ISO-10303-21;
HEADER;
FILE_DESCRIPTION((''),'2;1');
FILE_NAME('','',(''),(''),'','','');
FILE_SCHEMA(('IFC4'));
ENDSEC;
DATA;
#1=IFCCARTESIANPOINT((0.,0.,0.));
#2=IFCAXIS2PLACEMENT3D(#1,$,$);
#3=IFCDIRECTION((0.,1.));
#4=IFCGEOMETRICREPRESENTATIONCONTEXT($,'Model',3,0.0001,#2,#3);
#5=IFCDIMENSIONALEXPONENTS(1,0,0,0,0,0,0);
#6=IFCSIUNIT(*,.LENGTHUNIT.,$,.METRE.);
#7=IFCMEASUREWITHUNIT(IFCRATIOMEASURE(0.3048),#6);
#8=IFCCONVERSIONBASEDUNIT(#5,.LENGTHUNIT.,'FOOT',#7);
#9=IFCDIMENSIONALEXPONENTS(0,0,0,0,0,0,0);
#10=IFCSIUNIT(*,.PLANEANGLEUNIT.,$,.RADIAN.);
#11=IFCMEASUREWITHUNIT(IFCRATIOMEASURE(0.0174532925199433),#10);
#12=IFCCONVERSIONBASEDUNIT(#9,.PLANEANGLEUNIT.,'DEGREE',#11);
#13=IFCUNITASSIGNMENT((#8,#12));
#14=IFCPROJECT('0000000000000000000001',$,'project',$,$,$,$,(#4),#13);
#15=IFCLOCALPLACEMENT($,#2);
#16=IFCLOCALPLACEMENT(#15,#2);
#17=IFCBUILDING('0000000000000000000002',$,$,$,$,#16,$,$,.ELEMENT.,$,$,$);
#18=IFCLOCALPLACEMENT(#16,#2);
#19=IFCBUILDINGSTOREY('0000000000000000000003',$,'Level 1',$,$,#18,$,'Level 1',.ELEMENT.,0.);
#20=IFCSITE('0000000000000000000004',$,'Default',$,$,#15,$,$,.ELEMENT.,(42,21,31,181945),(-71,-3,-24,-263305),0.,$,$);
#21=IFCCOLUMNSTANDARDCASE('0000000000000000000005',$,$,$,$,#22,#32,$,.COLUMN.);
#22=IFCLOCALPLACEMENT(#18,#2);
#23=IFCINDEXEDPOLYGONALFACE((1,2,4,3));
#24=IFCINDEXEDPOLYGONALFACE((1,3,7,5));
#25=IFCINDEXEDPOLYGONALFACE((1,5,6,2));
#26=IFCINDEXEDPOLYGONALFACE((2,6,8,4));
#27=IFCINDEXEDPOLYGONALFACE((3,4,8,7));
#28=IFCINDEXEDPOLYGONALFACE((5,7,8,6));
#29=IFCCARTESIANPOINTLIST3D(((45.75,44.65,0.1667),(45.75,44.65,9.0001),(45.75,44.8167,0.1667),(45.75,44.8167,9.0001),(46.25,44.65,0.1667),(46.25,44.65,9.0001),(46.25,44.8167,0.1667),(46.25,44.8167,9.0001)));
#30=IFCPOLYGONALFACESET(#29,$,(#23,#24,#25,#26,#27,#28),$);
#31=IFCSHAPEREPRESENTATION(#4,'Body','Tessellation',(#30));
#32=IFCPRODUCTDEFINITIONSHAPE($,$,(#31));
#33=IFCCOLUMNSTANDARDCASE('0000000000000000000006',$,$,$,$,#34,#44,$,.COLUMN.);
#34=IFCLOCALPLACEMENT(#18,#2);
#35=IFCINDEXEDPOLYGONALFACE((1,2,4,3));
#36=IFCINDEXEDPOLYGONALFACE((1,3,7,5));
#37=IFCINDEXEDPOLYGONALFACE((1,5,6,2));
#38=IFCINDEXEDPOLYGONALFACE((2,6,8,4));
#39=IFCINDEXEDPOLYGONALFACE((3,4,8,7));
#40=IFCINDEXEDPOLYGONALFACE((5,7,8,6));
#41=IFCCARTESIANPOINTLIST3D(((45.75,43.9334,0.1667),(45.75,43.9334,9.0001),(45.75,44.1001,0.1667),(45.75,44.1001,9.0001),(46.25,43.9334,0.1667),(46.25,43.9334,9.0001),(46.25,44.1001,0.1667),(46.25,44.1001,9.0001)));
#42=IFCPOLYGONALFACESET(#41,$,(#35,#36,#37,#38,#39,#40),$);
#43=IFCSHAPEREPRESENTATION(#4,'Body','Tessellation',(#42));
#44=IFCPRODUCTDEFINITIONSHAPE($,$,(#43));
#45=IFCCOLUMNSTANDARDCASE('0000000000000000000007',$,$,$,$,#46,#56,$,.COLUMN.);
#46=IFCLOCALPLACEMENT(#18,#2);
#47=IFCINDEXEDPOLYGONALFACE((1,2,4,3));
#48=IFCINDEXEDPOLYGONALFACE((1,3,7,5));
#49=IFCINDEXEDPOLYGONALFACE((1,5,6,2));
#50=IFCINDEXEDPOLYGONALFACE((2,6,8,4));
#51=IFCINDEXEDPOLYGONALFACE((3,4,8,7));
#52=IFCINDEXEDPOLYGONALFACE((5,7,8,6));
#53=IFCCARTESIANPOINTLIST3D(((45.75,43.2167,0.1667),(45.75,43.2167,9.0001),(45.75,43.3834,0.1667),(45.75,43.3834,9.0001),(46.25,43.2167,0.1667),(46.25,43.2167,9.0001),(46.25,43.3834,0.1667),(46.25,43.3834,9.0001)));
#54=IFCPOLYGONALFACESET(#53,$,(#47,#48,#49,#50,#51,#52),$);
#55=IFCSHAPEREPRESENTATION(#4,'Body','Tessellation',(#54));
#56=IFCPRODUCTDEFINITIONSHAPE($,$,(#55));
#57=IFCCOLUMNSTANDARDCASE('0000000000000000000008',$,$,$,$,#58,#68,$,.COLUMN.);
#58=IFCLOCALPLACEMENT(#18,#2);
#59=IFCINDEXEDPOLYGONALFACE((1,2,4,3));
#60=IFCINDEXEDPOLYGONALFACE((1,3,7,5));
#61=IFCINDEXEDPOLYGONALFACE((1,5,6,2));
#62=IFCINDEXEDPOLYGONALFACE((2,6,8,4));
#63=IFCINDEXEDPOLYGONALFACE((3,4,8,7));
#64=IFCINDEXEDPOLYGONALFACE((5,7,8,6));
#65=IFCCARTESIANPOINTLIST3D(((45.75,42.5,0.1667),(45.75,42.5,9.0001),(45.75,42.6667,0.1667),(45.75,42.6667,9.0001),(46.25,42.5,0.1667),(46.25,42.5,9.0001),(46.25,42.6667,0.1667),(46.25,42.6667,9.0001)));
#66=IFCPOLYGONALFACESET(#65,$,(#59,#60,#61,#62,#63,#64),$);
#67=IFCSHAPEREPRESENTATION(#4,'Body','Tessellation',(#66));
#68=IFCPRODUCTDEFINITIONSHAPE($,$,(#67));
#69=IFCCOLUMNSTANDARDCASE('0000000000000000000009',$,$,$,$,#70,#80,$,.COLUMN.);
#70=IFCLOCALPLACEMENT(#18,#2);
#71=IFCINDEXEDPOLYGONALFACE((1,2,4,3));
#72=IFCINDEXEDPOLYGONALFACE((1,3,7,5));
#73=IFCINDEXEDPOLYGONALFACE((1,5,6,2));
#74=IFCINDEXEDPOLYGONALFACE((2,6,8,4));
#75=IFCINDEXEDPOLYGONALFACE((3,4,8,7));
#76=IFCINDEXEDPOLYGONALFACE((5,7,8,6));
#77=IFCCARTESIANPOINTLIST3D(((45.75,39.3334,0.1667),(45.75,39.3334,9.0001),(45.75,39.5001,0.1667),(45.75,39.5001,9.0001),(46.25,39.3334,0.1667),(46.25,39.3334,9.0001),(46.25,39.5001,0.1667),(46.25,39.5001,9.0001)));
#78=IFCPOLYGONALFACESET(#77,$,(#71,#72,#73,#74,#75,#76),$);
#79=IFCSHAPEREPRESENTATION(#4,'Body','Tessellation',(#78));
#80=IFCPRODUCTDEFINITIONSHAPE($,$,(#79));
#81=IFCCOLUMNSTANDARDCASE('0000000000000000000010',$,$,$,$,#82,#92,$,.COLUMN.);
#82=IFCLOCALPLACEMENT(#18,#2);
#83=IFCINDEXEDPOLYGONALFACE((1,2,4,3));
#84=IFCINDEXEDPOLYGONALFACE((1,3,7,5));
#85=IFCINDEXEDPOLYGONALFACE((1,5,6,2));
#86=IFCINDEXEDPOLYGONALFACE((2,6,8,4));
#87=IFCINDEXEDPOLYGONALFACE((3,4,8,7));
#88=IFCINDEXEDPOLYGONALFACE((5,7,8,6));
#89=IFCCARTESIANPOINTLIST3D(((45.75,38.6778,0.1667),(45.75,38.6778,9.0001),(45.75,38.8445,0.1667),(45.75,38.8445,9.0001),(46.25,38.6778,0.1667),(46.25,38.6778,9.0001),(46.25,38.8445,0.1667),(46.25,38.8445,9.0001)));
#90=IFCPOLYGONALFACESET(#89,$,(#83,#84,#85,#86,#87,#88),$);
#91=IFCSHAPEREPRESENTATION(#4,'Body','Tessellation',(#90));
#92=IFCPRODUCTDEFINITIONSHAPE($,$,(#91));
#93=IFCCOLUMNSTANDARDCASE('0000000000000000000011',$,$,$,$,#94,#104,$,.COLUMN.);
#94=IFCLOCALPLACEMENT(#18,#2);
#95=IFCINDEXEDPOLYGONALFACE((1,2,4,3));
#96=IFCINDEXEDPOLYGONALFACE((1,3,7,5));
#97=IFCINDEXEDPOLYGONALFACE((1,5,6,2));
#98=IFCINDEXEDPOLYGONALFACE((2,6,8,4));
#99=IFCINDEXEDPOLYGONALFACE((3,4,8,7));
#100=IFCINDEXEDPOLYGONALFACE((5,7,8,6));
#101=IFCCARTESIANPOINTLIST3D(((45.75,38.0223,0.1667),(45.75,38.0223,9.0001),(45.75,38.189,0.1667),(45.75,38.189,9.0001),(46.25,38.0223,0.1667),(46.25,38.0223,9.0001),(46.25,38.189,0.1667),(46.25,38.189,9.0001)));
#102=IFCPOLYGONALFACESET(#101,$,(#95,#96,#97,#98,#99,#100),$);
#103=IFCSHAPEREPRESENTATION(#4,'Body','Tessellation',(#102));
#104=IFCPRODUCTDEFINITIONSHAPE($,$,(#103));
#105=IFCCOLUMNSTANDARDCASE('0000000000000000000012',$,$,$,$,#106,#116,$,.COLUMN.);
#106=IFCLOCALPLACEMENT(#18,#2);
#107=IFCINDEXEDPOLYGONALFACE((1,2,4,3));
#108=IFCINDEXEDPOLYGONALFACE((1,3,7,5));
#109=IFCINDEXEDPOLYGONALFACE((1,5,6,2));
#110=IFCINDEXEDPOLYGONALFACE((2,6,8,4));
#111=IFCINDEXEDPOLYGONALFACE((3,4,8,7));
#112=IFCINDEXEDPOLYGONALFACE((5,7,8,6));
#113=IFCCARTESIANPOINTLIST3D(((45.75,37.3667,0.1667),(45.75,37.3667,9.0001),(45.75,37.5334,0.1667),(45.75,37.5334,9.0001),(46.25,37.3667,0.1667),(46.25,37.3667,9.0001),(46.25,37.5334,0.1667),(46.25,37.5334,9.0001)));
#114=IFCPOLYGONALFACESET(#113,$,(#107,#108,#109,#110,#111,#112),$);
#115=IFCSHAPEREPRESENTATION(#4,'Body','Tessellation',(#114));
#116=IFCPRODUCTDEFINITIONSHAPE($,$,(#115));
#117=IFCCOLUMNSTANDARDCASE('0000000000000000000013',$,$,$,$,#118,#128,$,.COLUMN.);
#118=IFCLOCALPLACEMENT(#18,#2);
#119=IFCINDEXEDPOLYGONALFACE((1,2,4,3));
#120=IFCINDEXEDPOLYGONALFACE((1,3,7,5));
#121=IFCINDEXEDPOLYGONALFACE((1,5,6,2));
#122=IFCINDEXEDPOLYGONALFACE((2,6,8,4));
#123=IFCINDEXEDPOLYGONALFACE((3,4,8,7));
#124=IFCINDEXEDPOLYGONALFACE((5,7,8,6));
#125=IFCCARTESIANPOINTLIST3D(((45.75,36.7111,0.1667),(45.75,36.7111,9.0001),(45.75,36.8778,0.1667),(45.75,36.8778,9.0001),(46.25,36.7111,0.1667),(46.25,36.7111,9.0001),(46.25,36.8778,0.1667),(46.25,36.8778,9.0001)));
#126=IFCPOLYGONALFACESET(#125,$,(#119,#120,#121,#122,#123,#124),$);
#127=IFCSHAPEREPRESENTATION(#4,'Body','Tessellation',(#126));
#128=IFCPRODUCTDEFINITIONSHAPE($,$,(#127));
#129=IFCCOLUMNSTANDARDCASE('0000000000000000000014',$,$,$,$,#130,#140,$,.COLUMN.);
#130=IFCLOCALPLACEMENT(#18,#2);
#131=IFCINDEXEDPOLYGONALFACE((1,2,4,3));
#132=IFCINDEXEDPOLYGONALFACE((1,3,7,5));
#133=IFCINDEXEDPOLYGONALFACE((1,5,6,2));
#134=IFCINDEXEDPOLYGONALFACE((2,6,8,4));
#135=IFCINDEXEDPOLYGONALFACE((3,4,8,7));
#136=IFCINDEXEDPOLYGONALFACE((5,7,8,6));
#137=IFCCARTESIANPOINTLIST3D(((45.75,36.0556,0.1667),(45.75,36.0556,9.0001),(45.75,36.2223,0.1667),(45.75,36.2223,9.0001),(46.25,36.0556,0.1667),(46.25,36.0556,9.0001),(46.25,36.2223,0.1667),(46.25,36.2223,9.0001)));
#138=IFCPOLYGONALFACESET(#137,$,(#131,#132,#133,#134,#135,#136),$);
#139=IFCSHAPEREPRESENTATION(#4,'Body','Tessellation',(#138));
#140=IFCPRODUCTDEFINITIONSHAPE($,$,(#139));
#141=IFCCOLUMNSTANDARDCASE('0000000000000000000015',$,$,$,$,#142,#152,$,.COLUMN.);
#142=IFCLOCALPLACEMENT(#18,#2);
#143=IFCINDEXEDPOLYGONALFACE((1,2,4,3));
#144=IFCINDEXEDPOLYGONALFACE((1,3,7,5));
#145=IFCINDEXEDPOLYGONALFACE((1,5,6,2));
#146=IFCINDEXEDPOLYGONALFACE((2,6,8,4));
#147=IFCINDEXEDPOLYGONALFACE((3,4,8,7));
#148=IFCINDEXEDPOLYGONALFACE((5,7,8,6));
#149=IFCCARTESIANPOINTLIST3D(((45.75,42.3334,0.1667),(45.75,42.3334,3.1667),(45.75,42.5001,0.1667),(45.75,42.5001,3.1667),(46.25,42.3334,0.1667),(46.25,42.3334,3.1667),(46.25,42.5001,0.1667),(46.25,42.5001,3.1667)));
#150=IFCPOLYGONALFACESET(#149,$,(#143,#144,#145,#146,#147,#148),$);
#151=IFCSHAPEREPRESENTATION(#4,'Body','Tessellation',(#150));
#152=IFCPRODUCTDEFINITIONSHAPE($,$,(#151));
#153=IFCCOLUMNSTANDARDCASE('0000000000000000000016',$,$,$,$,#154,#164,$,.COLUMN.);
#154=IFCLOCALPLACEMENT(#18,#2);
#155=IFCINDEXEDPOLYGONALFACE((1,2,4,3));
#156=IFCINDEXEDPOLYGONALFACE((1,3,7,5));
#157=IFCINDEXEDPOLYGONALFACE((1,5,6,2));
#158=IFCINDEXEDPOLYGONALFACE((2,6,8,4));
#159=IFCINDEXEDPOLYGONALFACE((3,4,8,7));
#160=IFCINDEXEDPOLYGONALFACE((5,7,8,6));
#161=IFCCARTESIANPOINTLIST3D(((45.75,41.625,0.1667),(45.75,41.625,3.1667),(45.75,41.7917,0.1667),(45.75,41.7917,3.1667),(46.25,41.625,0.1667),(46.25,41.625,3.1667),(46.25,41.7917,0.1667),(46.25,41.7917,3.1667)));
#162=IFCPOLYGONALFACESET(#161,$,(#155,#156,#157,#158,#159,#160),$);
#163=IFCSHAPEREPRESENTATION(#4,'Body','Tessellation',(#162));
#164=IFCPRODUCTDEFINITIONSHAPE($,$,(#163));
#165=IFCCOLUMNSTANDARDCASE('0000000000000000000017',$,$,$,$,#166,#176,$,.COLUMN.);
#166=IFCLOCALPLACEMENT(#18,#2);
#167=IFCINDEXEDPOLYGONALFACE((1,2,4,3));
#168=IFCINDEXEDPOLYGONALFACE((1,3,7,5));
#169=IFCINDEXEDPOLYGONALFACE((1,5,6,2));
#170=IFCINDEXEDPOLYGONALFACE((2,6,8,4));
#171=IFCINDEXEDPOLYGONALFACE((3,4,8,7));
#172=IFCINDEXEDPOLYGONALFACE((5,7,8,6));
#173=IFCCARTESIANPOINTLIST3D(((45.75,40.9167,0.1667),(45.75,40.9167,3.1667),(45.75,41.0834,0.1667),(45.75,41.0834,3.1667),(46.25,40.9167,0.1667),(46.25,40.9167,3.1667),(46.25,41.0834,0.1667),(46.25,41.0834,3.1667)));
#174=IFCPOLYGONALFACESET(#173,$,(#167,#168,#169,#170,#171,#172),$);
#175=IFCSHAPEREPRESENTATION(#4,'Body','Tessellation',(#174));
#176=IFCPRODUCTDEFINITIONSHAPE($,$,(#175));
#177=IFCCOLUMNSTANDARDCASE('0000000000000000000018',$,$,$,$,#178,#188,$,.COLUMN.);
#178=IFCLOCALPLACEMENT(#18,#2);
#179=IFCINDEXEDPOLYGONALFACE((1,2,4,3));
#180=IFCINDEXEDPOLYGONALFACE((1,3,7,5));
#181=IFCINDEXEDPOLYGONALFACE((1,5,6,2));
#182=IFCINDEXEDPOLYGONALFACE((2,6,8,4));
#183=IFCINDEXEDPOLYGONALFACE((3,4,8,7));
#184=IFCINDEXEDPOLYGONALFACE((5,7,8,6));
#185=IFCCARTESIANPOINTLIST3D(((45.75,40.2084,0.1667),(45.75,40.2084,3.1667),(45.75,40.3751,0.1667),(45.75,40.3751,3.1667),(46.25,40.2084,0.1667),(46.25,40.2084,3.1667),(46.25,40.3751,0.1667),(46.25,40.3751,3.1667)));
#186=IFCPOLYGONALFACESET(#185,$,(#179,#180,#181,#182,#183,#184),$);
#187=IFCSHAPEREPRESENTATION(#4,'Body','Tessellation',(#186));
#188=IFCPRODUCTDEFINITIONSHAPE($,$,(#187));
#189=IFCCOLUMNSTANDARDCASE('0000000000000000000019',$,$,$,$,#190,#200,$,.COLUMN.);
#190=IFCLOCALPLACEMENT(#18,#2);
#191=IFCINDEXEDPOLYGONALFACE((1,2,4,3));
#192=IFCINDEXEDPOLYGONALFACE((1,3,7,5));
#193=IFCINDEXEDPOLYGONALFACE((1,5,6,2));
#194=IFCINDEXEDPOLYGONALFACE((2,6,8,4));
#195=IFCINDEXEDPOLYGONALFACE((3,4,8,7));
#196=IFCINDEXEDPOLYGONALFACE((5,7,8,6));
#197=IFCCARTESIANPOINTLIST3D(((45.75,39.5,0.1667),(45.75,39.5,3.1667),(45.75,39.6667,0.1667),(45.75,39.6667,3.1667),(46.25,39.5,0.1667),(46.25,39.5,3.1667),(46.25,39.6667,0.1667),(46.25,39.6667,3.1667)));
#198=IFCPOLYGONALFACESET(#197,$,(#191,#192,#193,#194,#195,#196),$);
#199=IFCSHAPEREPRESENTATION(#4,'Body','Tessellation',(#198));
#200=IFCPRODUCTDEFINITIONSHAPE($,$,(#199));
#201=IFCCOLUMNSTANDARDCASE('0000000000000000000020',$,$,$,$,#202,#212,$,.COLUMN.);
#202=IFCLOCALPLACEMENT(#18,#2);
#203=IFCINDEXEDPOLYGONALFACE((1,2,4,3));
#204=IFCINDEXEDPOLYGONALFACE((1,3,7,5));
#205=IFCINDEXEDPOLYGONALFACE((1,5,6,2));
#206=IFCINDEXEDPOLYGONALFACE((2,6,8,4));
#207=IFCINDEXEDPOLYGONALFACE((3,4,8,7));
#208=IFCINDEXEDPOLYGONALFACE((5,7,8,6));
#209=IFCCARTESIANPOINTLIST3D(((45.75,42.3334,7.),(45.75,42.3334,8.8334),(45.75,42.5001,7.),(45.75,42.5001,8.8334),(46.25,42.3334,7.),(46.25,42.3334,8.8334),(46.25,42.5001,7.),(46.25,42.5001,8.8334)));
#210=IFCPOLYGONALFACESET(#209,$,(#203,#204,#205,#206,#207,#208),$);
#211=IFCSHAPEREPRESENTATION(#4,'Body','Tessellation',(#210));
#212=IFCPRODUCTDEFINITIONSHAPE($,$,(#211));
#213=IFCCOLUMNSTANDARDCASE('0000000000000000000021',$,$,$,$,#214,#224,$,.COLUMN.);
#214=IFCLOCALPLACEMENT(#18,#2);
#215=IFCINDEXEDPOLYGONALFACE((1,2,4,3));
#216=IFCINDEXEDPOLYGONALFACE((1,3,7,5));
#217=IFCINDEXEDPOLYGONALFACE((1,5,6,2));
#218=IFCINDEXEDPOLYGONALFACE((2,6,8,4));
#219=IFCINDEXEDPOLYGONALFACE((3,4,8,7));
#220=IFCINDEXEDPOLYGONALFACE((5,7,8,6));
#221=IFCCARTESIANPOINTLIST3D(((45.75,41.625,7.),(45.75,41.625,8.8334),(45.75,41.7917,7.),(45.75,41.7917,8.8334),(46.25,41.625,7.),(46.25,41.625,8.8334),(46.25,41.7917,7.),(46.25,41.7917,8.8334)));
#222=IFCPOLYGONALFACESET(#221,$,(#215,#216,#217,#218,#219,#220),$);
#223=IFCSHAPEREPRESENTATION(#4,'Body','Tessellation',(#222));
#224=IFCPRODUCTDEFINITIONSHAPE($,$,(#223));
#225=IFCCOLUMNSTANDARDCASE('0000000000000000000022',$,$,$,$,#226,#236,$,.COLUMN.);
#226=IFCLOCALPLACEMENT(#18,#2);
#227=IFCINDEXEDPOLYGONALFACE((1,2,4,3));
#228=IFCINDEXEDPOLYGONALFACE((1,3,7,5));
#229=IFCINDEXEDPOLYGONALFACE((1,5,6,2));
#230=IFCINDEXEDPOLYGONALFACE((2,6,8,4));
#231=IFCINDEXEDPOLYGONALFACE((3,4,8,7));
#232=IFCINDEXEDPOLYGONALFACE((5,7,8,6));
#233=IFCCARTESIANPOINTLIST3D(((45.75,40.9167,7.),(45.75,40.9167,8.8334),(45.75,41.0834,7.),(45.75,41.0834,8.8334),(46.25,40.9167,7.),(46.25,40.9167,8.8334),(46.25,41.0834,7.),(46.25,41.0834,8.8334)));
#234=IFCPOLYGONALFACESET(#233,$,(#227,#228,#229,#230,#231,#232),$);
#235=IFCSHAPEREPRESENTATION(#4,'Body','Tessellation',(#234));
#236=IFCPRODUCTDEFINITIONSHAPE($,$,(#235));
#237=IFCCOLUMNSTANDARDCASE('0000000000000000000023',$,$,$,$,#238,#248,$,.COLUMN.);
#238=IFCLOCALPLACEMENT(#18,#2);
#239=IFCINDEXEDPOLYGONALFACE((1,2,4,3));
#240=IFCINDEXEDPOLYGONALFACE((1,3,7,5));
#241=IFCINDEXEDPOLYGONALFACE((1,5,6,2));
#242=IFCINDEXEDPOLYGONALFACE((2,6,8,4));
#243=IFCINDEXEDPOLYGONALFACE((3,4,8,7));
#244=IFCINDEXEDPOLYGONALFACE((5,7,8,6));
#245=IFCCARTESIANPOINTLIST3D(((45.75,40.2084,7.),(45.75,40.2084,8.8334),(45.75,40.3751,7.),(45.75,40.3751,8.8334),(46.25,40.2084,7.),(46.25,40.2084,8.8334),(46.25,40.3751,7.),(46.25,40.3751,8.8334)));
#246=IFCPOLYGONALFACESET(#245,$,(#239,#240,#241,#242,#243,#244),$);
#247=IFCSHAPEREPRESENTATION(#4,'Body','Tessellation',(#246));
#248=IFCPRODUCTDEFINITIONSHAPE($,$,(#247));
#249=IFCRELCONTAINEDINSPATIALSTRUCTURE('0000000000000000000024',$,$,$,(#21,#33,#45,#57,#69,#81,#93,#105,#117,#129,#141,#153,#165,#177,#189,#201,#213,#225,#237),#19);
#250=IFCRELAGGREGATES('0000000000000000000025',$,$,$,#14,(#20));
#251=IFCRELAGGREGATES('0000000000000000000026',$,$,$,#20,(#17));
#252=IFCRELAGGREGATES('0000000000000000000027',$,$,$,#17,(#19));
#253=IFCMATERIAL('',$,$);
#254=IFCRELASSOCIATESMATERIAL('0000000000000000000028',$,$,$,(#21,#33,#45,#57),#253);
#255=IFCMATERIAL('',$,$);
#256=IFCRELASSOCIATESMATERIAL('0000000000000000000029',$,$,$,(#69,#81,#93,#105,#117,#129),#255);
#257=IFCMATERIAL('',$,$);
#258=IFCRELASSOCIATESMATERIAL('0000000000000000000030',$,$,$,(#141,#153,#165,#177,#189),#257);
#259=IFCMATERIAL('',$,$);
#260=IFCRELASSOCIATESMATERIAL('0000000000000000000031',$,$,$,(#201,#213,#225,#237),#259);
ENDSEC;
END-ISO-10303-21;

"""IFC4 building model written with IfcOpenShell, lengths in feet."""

from ifc_helpers import new_model, entity, si_unit, converted_unit, direction, frame, origin, place, context, project, spatial, rectangle, extrude, material, element, save


model = new_model("IFC4")

# Units and contexts
model_context = context("Model", 3, precision=0.0001, world=origin(), true_north=direction((0.0, 1.0)))
ifc_project = project(units=[converted_unit("LENGTHUNIT", "FOOT", entity("IfcRatioMeasure", 0.3048), si_unit("LENGTHUNIT", "METRE"), dimensions=[1, 0, 0, 0, 0, 0, 0]), converted_unit("PLANEANGLEUNIT", "DEGREE", entity("IfcRatioMeasure", 0.0174532925199433), si_unit("PLANEANGLEUNIT", "RADIAN"), dimensions=[0, 0, 0, 0, 0, 0, 0])], contexts=[model_context])

# Site, building, storey
site_placement = place(None, origin())
site = spatial("IfcSite", under=ifc_project, at=site_placement, Name="Default", CompositionType="ELEMENT", RefLatitude=(42, 21, 31, 181945), RefLongitude=(-71, -3, -24, -263305), RefElevation=0.0)
building_placement = place(site_placement, origin())
building = spatial("IfcBuilding", under=site, at=building_placement, CompositionType="ELEMENT")
storey_placement = place(building_placement, origin())
storey = spatial("IfcBuildingStorey", under=building, at=storey_placement, Name="Level 1", LongName="Level 1", CompositionType="ELEMENT", Elevation=0.0)

# Columns
ifc_material_1 = material(Name="")
placement_1 = place(storey_placement, frame((46.0, 46.25, 0.0), z_axis=(0.0, 0.0, 1.0), x_axis=(0.0, -1.0, 0.0)))
for number, where, z_axis, x_axis in (
    (1, (1.5167, 0.0, 0.1667), (0.0, 0.0, 1.0), (1.0, 0.0, 0.0)),
    (2, (2.2333, 0.0, 0.1667), (0.0, 0.0, 1.0), (1.0, 0.0, 0.0)),
    (3, (2.95, 0.0, 0.1667), (0.0, 0.0, 1.0), (1.0, 0.0, 0.0)),
    (4, (3.6667, 0.0, 0.1667), (0.0, 0.0, 1.0), (1.0, 0.0, 0.0)),
):
    element("IfcColumnStandardCase", number, at=place(placement_1, frame(where, z_axis=z_axis, x_axis=x_axis)), inside=storey, material=ifc_material_1, PredefinedType="COLUMN", context=model_context, shape_type="SweptSolid", body=[
        extrude(rectangle(XDim=0.1667, YDim=0.5), origin(), (0.0, 0.0, 1.0), 8.8334),
    ])
ifc_material_2 = material(Name="")
for number, where, z_axis, x_axis in (
    (5, (6.8333, 0.0, 0.1667), (0.0, 0.0, 1.0), (1.0, 0.0, 0.0)),
    (6, (7.4889, 0.0, 0.1667), (0.0, 0.0, 1.0), (1.0, 0.0, 0.0)),
    (7, (8.1444, 0.0, 0.1667), (0.0, 0.0, 1.0), (1.0, 0.0, 0.0)),
    (8, (8.8, 0.0, 0.1667), (0.0, 0.0, 1.0), (1.0, 0.0, 0.0)),
    (9, (9.4556, 0.0, 0.1667), (0.0, 0.0, 1.0), (1.0, 0.0, 0.0)),
    (10, (10.1111, 0.0, 0.1667), (0.0, 0.0, 1.0), (1.0, 0.0, 0.0)),
):
    element("IfcColumnStandardCase", number, at=place(placement_1, frame(where, z_axis=z_axis, x_axis=x_axis)), inside=storey, material=ifc_material_2, PredefinedType="COLUMN", context=model_context, shape_type="SweptSolid", body=[
        extrude(rectangle(XDim=0.1667, YDim=0.5), origin(), (0.0, 0.0, 1.0), 8.8334),
    ])
ifc_material_3 = material(Name="")
for number, where, z_axis, x_axis in (
    (11, (3.8333, 0.0, 0.1667), (0.0, 0.0, 1.0), (1.0, 0.0, 0.0)),
    (12, (4.5417, 0.0, 0.1667), (0.0, 0.0, 1.0), (1.0, 0.0, 0.0)),
    (13, (5.25, 0.0, 0.1667), (0.0, 0.0, 1.0), (1.0, 0.0, 0.0)),
    (14, (5.9583, 0.0, 0.1667), (0.0, 0.0, 1.0), (1.0, 0.0, 0.0)),
    (15, (6.6667, 0.0, 0.1667), (0.0, 0.0, 1.0), (1.0, 0.0, 0.0)),
):
    element("IfcColumnStandardCase", number, at=place(placement_1, frame(where, z_axis=z_axis, x_axis=x_axis)), inside=storey, material=ifc_material_3, PredefinedType="COLUMN", context=model_context, shape_type="SweptSolid", body=[
        extrude(rectangle(XDim=0.1667, YDim=0.5), origin(), (0.0, 0.0, 1.0), 3.0),
    ])
ifc_material_4 = material(Name="")
for number, where, z_axis, x_axis in (
    (16, (3.8333, 0.0, 7.0), (0.0, 0.0, 1.0), (1.0, 0.0, 0.0)),
    (17, (4.5417, 0.0, 7.0), (0.0, 0.0, 1.0), (1.0, 0.0, 0.0)),
    (18, (5.25, 0.0, 7.0), (0.0, 0.0, 1.0), (1.0, 0.0, 0.0)),
    (19, (5.9583, 0.0, 7.0), (0.0, 0.0, 1.0), (1.0, 0.0, 0.0)),
):
    element("IfcColumnStandardCase", number, at=place(placement_1, frame(where, z_axis=z_axis, x_axis=x_axis)), inside=storey, material=ifc_material_4, PredefinedType="COLUMN", context=model_context, shape_type="SweptSolid", body=[
        extrude(rectangle(XDim=0.1667, YDim=0.5), origin(), (0.0, 0.0, 1.0), 1.8334),
    ])

save(model, "model.ifc")
